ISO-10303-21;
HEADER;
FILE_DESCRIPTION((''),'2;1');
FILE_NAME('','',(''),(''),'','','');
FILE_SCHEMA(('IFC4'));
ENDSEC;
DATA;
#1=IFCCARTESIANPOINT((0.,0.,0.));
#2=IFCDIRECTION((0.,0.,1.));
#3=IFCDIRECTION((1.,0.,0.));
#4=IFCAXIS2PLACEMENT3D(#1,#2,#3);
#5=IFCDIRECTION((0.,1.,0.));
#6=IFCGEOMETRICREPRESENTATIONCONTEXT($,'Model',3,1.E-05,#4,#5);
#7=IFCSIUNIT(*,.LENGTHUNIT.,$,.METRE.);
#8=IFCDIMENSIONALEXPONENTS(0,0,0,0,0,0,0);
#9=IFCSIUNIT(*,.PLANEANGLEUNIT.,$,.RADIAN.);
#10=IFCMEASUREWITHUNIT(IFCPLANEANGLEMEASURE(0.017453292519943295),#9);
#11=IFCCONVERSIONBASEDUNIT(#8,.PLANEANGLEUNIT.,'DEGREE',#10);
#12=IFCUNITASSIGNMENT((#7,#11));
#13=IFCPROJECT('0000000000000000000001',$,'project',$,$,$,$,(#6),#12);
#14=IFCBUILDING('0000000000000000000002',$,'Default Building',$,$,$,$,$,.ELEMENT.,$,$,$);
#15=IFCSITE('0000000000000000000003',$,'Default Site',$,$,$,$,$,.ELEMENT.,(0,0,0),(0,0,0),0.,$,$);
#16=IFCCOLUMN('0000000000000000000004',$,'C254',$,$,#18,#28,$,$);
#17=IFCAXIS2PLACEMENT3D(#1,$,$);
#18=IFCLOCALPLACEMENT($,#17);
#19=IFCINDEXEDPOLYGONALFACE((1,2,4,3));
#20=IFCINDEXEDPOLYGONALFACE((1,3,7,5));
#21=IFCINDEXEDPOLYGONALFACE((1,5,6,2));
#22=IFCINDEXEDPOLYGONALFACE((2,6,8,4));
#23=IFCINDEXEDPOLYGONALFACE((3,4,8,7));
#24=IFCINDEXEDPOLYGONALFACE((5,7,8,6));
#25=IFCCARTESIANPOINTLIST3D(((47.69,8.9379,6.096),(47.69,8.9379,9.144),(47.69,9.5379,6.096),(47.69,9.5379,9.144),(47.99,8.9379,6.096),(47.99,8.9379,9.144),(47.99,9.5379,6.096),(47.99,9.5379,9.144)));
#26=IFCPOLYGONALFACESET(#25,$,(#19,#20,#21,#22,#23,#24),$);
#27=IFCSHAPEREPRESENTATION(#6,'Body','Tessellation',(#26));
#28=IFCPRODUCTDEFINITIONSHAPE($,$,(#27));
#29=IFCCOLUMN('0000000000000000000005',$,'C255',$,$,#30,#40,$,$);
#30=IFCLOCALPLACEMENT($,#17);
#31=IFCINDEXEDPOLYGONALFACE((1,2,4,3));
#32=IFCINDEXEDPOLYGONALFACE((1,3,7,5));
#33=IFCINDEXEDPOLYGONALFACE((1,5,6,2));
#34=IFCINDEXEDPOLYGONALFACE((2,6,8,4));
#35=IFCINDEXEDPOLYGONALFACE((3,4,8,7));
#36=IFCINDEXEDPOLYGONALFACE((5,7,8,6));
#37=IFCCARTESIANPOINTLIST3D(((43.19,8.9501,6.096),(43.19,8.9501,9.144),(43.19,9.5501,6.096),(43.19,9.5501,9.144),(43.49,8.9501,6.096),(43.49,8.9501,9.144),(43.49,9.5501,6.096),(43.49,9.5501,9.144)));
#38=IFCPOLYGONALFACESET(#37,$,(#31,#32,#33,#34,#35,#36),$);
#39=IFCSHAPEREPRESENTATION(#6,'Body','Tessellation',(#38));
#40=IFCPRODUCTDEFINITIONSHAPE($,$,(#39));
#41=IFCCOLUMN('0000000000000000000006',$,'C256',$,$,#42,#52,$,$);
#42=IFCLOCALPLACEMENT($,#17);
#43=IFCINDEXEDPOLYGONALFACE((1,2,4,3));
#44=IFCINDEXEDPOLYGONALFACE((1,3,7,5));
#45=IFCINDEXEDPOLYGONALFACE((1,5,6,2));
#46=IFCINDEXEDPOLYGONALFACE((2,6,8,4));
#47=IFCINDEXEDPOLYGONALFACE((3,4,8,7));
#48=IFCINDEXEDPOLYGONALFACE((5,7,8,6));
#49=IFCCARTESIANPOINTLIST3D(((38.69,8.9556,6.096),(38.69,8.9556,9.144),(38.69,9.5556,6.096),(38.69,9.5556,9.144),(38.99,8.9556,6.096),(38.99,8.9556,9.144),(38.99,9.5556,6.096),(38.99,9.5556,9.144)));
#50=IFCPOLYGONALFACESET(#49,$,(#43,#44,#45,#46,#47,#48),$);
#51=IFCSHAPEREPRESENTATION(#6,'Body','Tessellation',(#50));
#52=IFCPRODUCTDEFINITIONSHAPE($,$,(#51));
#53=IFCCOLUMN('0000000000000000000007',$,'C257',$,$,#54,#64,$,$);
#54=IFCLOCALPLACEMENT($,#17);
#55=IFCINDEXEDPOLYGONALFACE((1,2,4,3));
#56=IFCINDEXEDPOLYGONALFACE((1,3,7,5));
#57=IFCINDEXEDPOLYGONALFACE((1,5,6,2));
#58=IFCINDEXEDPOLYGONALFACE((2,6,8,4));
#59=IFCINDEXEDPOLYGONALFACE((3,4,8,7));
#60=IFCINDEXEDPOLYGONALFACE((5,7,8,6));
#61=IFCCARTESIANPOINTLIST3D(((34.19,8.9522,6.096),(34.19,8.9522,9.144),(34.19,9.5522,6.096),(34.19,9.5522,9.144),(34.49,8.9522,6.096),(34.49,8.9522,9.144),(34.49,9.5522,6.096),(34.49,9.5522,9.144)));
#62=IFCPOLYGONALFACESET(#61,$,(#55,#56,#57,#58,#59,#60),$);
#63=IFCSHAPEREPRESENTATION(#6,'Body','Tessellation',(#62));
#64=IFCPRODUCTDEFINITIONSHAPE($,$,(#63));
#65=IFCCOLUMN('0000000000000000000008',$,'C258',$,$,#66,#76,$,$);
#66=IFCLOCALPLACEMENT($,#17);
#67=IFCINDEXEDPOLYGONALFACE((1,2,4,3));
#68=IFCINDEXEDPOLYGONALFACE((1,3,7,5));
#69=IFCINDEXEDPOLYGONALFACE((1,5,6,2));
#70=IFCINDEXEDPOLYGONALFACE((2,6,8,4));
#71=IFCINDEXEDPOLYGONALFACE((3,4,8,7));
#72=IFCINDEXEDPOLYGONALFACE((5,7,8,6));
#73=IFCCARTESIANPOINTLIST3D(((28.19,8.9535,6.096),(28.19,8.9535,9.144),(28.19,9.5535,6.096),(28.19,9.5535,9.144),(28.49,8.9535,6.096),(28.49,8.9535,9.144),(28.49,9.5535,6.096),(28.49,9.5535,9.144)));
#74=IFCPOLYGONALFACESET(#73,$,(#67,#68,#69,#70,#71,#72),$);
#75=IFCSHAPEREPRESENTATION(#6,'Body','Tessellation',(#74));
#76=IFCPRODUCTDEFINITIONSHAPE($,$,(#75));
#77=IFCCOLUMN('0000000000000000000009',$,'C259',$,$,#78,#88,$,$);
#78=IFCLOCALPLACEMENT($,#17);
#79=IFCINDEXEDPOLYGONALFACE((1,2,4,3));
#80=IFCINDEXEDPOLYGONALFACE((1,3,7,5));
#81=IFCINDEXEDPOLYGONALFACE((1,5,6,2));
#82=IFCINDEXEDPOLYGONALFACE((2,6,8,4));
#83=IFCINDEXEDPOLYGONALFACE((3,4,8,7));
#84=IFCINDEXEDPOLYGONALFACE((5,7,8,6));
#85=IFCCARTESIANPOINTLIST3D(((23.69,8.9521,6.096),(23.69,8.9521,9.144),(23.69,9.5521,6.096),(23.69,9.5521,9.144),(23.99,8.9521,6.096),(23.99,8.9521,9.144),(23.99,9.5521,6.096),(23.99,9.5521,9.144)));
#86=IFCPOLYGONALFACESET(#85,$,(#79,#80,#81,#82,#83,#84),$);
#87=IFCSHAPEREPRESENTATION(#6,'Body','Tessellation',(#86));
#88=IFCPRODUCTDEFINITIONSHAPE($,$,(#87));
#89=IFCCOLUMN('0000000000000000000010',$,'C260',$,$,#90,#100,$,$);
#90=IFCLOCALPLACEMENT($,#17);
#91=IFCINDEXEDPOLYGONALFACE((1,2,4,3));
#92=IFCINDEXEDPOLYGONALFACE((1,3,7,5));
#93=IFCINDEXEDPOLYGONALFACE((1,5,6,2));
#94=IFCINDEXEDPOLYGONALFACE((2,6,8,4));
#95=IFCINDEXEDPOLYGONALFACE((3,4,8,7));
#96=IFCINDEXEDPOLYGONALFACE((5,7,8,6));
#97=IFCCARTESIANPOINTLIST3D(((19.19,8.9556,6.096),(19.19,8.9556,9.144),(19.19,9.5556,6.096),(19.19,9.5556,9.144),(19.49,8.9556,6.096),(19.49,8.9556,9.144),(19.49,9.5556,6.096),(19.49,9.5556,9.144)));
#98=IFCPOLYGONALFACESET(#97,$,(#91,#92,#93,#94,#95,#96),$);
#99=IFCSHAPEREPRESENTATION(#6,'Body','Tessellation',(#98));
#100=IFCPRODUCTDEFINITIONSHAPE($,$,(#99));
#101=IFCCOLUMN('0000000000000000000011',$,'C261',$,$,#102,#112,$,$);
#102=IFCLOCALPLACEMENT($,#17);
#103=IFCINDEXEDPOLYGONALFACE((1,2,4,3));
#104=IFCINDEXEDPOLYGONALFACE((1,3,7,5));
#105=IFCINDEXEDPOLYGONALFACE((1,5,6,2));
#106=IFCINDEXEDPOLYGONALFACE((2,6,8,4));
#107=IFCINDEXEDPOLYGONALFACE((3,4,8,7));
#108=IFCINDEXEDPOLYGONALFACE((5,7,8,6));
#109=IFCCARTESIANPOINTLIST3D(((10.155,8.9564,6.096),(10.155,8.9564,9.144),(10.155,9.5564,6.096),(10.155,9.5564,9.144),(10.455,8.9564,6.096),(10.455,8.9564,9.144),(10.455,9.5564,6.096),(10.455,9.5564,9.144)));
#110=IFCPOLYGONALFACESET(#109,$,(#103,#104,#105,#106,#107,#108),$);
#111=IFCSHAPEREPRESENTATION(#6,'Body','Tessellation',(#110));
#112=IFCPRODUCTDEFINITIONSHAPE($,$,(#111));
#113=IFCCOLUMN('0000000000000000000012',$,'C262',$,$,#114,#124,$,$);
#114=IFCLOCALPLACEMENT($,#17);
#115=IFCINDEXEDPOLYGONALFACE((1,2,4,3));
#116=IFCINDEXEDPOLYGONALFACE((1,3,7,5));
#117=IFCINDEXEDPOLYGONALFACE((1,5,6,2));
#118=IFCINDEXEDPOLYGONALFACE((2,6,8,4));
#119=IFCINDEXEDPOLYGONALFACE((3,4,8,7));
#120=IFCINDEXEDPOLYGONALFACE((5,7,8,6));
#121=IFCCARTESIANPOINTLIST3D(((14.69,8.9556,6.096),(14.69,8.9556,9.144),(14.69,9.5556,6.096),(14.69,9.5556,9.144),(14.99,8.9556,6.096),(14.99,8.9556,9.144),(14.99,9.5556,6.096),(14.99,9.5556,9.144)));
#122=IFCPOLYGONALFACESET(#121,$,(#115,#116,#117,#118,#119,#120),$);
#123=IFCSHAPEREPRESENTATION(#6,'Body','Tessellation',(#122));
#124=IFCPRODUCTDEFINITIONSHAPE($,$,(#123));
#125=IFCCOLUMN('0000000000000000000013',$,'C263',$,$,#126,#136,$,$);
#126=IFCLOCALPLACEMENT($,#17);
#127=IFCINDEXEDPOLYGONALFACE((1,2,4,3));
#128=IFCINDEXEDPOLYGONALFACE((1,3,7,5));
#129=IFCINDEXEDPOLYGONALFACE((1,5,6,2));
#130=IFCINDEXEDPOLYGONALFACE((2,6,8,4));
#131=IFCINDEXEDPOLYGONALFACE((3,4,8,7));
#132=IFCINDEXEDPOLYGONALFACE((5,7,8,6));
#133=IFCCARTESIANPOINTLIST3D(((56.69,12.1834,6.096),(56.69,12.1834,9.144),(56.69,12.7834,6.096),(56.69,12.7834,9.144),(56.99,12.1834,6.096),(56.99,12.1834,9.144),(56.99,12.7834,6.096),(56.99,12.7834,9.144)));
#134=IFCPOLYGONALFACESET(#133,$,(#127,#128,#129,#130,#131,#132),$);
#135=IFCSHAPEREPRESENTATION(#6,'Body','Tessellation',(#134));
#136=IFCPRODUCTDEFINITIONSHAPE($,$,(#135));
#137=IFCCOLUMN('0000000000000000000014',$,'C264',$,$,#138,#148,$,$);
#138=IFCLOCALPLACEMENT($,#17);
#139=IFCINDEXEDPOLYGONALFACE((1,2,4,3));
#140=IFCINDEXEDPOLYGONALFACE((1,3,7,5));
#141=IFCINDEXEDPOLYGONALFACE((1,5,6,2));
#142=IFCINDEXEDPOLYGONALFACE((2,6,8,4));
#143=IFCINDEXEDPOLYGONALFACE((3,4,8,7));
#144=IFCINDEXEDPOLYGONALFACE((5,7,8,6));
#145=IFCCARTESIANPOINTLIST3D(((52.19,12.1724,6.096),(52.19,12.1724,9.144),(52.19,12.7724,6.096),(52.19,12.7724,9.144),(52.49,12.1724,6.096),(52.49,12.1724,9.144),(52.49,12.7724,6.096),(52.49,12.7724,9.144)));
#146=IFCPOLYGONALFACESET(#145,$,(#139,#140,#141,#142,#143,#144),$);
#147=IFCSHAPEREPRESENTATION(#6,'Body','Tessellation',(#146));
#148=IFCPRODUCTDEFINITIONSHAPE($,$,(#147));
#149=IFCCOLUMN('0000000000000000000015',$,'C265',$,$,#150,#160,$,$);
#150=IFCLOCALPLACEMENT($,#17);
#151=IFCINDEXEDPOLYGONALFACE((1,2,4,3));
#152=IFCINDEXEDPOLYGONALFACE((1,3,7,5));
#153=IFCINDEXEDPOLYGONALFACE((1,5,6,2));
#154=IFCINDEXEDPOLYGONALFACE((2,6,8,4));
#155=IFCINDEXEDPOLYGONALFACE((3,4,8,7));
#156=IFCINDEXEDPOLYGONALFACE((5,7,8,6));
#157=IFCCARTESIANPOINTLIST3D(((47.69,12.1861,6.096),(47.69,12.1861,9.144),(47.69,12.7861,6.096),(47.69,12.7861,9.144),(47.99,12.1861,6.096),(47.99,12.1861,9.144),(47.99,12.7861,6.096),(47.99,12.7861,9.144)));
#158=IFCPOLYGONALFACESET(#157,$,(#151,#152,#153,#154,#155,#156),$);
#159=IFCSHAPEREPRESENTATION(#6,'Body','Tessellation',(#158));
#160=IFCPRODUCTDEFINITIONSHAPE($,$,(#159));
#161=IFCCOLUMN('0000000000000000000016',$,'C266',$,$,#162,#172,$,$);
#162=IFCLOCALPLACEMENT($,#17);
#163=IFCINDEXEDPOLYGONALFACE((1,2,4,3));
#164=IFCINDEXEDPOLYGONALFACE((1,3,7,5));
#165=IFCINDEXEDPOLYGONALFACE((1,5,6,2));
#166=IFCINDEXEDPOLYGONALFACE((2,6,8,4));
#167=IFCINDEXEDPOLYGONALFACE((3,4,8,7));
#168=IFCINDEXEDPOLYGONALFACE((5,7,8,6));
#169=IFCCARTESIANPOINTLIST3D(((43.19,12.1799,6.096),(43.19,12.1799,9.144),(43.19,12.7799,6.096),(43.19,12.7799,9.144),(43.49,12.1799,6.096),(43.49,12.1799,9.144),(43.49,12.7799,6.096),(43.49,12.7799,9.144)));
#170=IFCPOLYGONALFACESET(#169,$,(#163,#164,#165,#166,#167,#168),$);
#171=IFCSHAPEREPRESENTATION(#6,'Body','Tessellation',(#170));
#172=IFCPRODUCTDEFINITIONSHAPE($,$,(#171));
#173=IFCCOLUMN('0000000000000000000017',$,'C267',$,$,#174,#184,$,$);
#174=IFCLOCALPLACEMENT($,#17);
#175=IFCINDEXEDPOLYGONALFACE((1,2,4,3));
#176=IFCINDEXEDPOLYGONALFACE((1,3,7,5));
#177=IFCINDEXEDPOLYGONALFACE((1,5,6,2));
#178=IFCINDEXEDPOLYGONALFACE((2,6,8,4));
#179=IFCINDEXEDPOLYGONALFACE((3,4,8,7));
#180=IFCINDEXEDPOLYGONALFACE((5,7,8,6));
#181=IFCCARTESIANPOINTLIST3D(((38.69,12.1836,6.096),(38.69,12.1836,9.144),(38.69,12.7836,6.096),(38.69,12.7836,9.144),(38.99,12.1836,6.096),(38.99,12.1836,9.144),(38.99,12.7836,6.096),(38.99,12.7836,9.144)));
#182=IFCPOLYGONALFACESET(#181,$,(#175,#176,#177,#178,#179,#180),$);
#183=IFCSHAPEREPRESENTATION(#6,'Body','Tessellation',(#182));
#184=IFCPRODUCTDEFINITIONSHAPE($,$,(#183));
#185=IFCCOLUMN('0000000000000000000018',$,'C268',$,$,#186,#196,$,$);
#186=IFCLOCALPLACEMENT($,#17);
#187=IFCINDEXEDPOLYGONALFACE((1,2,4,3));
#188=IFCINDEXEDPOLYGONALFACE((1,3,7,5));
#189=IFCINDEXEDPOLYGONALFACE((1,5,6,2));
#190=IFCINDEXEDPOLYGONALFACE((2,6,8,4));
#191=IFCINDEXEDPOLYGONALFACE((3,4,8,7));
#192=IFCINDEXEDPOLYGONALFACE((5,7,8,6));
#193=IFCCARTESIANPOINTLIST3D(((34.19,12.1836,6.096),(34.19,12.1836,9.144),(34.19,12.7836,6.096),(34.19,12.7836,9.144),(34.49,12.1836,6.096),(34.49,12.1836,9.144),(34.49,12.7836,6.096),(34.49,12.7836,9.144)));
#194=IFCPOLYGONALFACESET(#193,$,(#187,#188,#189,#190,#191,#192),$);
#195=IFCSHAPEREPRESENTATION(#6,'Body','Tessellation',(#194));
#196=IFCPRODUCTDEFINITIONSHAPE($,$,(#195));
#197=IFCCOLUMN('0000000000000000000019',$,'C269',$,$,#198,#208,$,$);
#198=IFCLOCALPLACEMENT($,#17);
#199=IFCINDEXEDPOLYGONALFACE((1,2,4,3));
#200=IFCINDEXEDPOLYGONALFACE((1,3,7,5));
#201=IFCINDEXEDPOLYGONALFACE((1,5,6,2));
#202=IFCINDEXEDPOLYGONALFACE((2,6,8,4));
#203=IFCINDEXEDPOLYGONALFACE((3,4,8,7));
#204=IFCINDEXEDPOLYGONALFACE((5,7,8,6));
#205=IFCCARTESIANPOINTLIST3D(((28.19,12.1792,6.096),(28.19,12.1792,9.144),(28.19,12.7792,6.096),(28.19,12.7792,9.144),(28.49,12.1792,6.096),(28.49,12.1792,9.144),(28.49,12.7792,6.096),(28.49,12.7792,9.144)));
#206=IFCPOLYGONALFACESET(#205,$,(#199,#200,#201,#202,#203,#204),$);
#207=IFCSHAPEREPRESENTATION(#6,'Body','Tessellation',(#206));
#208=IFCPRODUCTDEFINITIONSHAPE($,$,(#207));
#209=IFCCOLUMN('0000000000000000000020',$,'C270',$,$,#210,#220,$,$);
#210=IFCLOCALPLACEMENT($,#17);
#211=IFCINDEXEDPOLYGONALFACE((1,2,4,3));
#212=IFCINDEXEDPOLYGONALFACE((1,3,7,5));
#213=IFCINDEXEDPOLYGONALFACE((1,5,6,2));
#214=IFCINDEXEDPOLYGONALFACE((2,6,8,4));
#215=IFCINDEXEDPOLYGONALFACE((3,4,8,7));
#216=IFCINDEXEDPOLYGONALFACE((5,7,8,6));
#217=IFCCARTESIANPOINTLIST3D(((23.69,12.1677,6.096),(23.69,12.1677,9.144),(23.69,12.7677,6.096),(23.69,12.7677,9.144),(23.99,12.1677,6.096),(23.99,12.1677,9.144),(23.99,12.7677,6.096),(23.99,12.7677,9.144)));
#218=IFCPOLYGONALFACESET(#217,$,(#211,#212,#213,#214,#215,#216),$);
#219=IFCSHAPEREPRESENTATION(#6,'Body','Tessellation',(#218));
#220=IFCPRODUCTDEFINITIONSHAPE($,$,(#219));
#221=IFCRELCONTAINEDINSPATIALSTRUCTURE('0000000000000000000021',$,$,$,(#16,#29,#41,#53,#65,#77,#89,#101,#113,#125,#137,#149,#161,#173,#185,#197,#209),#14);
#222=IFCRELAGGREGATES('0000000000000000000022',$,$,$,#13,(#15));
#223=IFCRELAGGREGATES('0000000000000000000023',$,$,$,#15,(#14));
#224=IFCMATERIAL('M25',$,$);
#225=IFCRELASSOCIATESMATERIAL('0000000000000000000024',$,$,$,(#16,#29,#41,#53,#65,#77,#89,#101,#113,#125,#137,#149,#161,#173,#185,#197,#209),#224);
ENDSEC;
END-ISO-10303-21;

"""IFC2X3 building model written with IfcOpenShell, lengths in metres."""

from ifc_helpers import new_model, entity, si_unit, converted_unit, direction, frame, frame_2d, origin_with_axes, place, context, project, spatial, rectangle, extrude, material, element, save


model = new_model("IFC2X3")

# Units and contexts
model_context = context("Model", 3, precision=1e-05, world=origin_with_axes(), true_north=direction((0.0, 1.0, 0.0)))
ifc_project = project(units=[si_unit("LENGTHUNIT", "METRE"), converted_unit("PLANEANGLEUNIT", "DEGREE", entity("IfcPlaneAngleMeasure", 0.017453292519943295), si_unit("PLANEANGLEUNIT", "RADIAN"), dimensions=[0, 0, 0, 0, 0, 0, 0])], contexts=[model_context])

# Site, building
site = spatial("IfcSite", under=ifc_project, Name="Default Site", CompositionType="ELEMENT", RefLatitude=(0, 0, 0), RefLongitude=(0, 0, 0), RefElevation=0.0)
building = spatial("IfcBuilding", under=site, Name="Default Building", CompositionType="ELEMENT")

# Columns
ifc_material = material(Name="M25")
placement = place(None, origin_with_axes())
element("IfcColumn", 1, at=placement, inside=building, material=ifc_material, Name="C254", context=model_context, shape_type="SweptSolid", body=[
    extrude(rectangle(XDim=0.3, YDim=0.6, at=frame_2d((0.0, 0.0), x_axis=(1.0, 0.0, 0.0))), frame((47.84, 9.2379, 6.096), z_axis=(0.0, 0.0, 1.0), x_axis=(1.0, 0.0, 0.0)), (0.0, 0.0, 1.0), 3.048),
])
element("IfcColumn", 2, at=placement, inside=building, material=ifc_material, Name="C255", context=model_context, shape_type="SweptSolid", body=[
    extrude(rectangle(XDim=0.3, YDim=0.6, at=frame_2d((0.0, 0.0), x_axis=(1.0, 0.0, 0.0))), frame((43.34, 9.2501, 6.096), z_axis=(0.0, 0.0, 1.0), x_axis=(1.0, 0.0, 0.0)), (0.0, 0.0, 1.0), 3.048),
])
element("IfcColumn", 3, at=placement, inside=building, material=ifc_material, Name="C256", context=model_context, shape_type="SweptSolid", body=[
    extrude(rectangle(XDim=0.3, YDim=0.6, at=frame_2d((0.0, 0.0), x_axis=(1.0, 0.0, 0.0))), frame((38.84, 9.2556, 6.096), z_axis=(0.0, 0.0, 1.0), x_axis=(1.0, 0.0, 0.0)), (0.0, 0.0, 1.0), 3.048),
])
element("IfcColumn", 4, at=placement, inside=building, material=ifc_material, Name="C257", context=model_context, shape_type="SweptSolid", body=[
    extrude(rectangle(XDim=0.3, YDim=0.6, at=frame_2d((0.0, 0.0), x_axis=(1.0, 0.0, 0.0))), frame((34.34, 9.2522, 6.096), z_axis=(0.0, 0.0, 1.0), x_axis=(1.0, 0.0, 0.0)), (0.0, 0.0, 1.0), 3.048),
])
element("IfcColumn", 5, at=placement, inside=building, material=ifc_material, Name="C258", context=model_context, shape_type="SweptSolid", body=[
    extrude(rectangle(XDim=0.3, YDim=0.6, at=frame_2d((0.0, 0.0), x_axis=(1.0, 0.0, 0.0))), frame((28.34, 9.2535, 6.096), z_axis=(0.0, 0.0, 1.0), x_axis=(1.0, 0.0, 0.0)), (0.0, 0.0, 1.0), 3.048),
])
element("IfcColumn", 6, at=placement, inside=building, material=ifc_material, Name="C259", context=model_context, shape_type="SweptSolid", body=[
    extrude(rectangle(XDim=0.3, YDim=0.6, at=frame_2d((0.0, 0.0), x_axis=(1.0, 0.0, 0.0))), frame((23.84, 9.2521, 6.096), z_axis=(0.0, 0.0, 1.0), x_axis=(1.0, 0.0, 0.0)), (0.0, 0.0, 1.0), 3.048),
])
element("IfcColumn", 7, at=placement, inside=building, material=ifc_material, Name="C260", context=model_context, shape_type="SweptSolid", body=[
    extrude(rectangle(XDim=0.3, YDim=0.6, at=frame_2d((0.0, 0.0), x_axis=(1.0, 0.0, 0.0))), frame((19.34, 9.2556, 6.096), z_axis=(0.0, 0.0, 1.0), x_axis=(1.0, 0.0, 0.0)), (0.0, 0.0, 1.0), 3.048),
])
element("IfcColumn", 8, at=placement, inside=building, material=ifc_material, Name="C261", context=model_context, shape_type="SweptSolid", body=[
    extrude(rectangle(XDim=0.3, YDim=0.6, at=frame_2d((0.0, 0.0), x_axis=(1.0, 0.0, 0.0))), frame((10.305, 9.2564, 6.096), z_axis=(0.0, 0.0, 1.0), x_axis=(1.0, 0.0, 0.0)), (0.0, 0.0, 1.0), 3.048),
])
element("IfcColumn", 9, at=placement, inside=building, material=ifc_material, Name="C262", context=model_context, shape_type="SweptSolid", body=[
    extrude(rectangle(XDim=0.3, YDim=0.6, at=frame_2d((0.0, 0.0), x_axis=(1.0, 0.0, 0.0))), frame((14.84, 9.2556, 6.096), z_axis=(0.0, 0.0, 1.0), x_axis=(1.0, 0.0, 0.0)), (0.0, 0.0, 1.0), 3.048),
])
element("IfcColumn", 10, at=placement, inside=building, material=ifc_material, Name="C263", context=model_context, shape_type="SweptSolid", body=[
    extrude(rectangle(XDim=0.3, YDim=0.6, at=frame_2d((0.0, 0.0), x_axis=(1.0, 0.0, 0.0))), frame((56.84, 12.4834, 6.096), z_axis=(0.0, 0.0, 1.0), x_axis=(1.0, 0.0, 0.0)), (0.0, 0.0, 1.0), 3.048),
])
element("IfcColumn", 11, at=placement, inside=building, material=ifc_material, Name="C264", context=model_context, shape_type="SweptSolid", body=[
    extrude(rectangle(XDim=0.3, YDim=0.6, at=frame_2d((0.0, 0.0), x_axis=(1.0, 0.0, 0.0))), frame((52.34, 12.4724, 6.096), z_axis=(0.0, 0.0, 1.0), x_axis=(1.0, 0.0, 0.0)), (0.0, 0.0, 1.0), 3.048),
])
element("IfcColumn", 12, at=placement, inside=building, material=ifc_material, Name="C265", context=model_context, shape_type="SweptSolid", body=[
    extrude(rectangle(XDim=0.3, YDim=0.6, at=frame_2d((0.0, 0.0), x_axis=(1.0, 0.0, 0.0))), frame((47.84, 12.4861, 6.096), z_axis=(0.0, 0.0, 1.0), x_axis=(1.0, 0.0, 0.0)), (0.0, 0.0, 1.0), 3.048),
])
element("IfcColumn", 13, at=placement, inside=building, material=ifc_material, Name="C266", context=model_context, shape_type="SweptSolid", body=[
    extrude(rectangle(XDim=0.3, YDim=0.6, at=frame_2d((0.0, 0.0), x_axis=(1.0, 0.0, 0.0))), frame((43.34, 12.4799, 6.096), z_axis=(0.0, 0.0, 1.0), x_axis=(1.0, 0.0, 0.0)), (0.0, 0.0, 1.0), 3.048),
])
element("IfcColumn", 14, at=placement, inside=building, material=ifc_material, Name="C267", context=model_context, shape_type="SweptSolid", body=[
    extrude(rectangle(XDim=0.3, YDim=0.6, at=frame_2d((0.0, 0.0), x_axis=(1.0, 0.0, 0.0))), frame((38.84, 12.4836, 6.096), z_axis=(0.0, 0.0, 1.0), x_axis=(1.0, 0.0, 0.0)), (0.0, 0.0, 1.0), 3.048),
])
element("IfcColumn", 15, at=placement, inside=building, material=ifc_material, Name="C268", context=model_context, shape_type="SweptSolid", body=[
    extrude(rectangle(XDim=0.3, YDim=0.6, at=frame_2d((0.0, 0.0), x_axis=(1.0, 0.0, 0.0))), frame((34.34, 12.4836, 6.096), z_axis=(0.0, 0.0, 1.0), x_axis=(1.0, 0.0, 0.0)), (0.0, 0.0, 1.0), 3.048),
])
element("IfcColumn", 16, at=placement, inside=building, material=ifc_material, Name="C269", context=model_context, shape_type="SweptSolid", body=[
    extrude(rectangle(XDim=0.3, YDim=0.6, at=frame_2d((0.0, 0.0), x_axis=(1.0, 0.0, 0.0))), frame((28.34, 12.4792, 6.096), z_axis=(0.0, 0.0, 1.0), x_axis=(1.0, 0.0, 0.0)), (0.0, 0.0, 1.0), 3.048),
])
element("IfcColumn", 17, at=placement, inside=building, material=ifc_material, Name="C270", context=model_context, shape_type="SweptSolid", body=[
    extrude(rectangle(XDim=0.3, YDim=0.6, at=frame_2d((0.0, 0.0), x_axis=(1.0, 0.0, 0.0))), frame((23.84, 12.4677, 6.096), z_axis=(0.0, 0.0, 1.0), x_axis=(1.0, 0.0, 0.0)), (0.0, 0.0, 1.0), 3.048),
])

save(model, "model.ifc")
